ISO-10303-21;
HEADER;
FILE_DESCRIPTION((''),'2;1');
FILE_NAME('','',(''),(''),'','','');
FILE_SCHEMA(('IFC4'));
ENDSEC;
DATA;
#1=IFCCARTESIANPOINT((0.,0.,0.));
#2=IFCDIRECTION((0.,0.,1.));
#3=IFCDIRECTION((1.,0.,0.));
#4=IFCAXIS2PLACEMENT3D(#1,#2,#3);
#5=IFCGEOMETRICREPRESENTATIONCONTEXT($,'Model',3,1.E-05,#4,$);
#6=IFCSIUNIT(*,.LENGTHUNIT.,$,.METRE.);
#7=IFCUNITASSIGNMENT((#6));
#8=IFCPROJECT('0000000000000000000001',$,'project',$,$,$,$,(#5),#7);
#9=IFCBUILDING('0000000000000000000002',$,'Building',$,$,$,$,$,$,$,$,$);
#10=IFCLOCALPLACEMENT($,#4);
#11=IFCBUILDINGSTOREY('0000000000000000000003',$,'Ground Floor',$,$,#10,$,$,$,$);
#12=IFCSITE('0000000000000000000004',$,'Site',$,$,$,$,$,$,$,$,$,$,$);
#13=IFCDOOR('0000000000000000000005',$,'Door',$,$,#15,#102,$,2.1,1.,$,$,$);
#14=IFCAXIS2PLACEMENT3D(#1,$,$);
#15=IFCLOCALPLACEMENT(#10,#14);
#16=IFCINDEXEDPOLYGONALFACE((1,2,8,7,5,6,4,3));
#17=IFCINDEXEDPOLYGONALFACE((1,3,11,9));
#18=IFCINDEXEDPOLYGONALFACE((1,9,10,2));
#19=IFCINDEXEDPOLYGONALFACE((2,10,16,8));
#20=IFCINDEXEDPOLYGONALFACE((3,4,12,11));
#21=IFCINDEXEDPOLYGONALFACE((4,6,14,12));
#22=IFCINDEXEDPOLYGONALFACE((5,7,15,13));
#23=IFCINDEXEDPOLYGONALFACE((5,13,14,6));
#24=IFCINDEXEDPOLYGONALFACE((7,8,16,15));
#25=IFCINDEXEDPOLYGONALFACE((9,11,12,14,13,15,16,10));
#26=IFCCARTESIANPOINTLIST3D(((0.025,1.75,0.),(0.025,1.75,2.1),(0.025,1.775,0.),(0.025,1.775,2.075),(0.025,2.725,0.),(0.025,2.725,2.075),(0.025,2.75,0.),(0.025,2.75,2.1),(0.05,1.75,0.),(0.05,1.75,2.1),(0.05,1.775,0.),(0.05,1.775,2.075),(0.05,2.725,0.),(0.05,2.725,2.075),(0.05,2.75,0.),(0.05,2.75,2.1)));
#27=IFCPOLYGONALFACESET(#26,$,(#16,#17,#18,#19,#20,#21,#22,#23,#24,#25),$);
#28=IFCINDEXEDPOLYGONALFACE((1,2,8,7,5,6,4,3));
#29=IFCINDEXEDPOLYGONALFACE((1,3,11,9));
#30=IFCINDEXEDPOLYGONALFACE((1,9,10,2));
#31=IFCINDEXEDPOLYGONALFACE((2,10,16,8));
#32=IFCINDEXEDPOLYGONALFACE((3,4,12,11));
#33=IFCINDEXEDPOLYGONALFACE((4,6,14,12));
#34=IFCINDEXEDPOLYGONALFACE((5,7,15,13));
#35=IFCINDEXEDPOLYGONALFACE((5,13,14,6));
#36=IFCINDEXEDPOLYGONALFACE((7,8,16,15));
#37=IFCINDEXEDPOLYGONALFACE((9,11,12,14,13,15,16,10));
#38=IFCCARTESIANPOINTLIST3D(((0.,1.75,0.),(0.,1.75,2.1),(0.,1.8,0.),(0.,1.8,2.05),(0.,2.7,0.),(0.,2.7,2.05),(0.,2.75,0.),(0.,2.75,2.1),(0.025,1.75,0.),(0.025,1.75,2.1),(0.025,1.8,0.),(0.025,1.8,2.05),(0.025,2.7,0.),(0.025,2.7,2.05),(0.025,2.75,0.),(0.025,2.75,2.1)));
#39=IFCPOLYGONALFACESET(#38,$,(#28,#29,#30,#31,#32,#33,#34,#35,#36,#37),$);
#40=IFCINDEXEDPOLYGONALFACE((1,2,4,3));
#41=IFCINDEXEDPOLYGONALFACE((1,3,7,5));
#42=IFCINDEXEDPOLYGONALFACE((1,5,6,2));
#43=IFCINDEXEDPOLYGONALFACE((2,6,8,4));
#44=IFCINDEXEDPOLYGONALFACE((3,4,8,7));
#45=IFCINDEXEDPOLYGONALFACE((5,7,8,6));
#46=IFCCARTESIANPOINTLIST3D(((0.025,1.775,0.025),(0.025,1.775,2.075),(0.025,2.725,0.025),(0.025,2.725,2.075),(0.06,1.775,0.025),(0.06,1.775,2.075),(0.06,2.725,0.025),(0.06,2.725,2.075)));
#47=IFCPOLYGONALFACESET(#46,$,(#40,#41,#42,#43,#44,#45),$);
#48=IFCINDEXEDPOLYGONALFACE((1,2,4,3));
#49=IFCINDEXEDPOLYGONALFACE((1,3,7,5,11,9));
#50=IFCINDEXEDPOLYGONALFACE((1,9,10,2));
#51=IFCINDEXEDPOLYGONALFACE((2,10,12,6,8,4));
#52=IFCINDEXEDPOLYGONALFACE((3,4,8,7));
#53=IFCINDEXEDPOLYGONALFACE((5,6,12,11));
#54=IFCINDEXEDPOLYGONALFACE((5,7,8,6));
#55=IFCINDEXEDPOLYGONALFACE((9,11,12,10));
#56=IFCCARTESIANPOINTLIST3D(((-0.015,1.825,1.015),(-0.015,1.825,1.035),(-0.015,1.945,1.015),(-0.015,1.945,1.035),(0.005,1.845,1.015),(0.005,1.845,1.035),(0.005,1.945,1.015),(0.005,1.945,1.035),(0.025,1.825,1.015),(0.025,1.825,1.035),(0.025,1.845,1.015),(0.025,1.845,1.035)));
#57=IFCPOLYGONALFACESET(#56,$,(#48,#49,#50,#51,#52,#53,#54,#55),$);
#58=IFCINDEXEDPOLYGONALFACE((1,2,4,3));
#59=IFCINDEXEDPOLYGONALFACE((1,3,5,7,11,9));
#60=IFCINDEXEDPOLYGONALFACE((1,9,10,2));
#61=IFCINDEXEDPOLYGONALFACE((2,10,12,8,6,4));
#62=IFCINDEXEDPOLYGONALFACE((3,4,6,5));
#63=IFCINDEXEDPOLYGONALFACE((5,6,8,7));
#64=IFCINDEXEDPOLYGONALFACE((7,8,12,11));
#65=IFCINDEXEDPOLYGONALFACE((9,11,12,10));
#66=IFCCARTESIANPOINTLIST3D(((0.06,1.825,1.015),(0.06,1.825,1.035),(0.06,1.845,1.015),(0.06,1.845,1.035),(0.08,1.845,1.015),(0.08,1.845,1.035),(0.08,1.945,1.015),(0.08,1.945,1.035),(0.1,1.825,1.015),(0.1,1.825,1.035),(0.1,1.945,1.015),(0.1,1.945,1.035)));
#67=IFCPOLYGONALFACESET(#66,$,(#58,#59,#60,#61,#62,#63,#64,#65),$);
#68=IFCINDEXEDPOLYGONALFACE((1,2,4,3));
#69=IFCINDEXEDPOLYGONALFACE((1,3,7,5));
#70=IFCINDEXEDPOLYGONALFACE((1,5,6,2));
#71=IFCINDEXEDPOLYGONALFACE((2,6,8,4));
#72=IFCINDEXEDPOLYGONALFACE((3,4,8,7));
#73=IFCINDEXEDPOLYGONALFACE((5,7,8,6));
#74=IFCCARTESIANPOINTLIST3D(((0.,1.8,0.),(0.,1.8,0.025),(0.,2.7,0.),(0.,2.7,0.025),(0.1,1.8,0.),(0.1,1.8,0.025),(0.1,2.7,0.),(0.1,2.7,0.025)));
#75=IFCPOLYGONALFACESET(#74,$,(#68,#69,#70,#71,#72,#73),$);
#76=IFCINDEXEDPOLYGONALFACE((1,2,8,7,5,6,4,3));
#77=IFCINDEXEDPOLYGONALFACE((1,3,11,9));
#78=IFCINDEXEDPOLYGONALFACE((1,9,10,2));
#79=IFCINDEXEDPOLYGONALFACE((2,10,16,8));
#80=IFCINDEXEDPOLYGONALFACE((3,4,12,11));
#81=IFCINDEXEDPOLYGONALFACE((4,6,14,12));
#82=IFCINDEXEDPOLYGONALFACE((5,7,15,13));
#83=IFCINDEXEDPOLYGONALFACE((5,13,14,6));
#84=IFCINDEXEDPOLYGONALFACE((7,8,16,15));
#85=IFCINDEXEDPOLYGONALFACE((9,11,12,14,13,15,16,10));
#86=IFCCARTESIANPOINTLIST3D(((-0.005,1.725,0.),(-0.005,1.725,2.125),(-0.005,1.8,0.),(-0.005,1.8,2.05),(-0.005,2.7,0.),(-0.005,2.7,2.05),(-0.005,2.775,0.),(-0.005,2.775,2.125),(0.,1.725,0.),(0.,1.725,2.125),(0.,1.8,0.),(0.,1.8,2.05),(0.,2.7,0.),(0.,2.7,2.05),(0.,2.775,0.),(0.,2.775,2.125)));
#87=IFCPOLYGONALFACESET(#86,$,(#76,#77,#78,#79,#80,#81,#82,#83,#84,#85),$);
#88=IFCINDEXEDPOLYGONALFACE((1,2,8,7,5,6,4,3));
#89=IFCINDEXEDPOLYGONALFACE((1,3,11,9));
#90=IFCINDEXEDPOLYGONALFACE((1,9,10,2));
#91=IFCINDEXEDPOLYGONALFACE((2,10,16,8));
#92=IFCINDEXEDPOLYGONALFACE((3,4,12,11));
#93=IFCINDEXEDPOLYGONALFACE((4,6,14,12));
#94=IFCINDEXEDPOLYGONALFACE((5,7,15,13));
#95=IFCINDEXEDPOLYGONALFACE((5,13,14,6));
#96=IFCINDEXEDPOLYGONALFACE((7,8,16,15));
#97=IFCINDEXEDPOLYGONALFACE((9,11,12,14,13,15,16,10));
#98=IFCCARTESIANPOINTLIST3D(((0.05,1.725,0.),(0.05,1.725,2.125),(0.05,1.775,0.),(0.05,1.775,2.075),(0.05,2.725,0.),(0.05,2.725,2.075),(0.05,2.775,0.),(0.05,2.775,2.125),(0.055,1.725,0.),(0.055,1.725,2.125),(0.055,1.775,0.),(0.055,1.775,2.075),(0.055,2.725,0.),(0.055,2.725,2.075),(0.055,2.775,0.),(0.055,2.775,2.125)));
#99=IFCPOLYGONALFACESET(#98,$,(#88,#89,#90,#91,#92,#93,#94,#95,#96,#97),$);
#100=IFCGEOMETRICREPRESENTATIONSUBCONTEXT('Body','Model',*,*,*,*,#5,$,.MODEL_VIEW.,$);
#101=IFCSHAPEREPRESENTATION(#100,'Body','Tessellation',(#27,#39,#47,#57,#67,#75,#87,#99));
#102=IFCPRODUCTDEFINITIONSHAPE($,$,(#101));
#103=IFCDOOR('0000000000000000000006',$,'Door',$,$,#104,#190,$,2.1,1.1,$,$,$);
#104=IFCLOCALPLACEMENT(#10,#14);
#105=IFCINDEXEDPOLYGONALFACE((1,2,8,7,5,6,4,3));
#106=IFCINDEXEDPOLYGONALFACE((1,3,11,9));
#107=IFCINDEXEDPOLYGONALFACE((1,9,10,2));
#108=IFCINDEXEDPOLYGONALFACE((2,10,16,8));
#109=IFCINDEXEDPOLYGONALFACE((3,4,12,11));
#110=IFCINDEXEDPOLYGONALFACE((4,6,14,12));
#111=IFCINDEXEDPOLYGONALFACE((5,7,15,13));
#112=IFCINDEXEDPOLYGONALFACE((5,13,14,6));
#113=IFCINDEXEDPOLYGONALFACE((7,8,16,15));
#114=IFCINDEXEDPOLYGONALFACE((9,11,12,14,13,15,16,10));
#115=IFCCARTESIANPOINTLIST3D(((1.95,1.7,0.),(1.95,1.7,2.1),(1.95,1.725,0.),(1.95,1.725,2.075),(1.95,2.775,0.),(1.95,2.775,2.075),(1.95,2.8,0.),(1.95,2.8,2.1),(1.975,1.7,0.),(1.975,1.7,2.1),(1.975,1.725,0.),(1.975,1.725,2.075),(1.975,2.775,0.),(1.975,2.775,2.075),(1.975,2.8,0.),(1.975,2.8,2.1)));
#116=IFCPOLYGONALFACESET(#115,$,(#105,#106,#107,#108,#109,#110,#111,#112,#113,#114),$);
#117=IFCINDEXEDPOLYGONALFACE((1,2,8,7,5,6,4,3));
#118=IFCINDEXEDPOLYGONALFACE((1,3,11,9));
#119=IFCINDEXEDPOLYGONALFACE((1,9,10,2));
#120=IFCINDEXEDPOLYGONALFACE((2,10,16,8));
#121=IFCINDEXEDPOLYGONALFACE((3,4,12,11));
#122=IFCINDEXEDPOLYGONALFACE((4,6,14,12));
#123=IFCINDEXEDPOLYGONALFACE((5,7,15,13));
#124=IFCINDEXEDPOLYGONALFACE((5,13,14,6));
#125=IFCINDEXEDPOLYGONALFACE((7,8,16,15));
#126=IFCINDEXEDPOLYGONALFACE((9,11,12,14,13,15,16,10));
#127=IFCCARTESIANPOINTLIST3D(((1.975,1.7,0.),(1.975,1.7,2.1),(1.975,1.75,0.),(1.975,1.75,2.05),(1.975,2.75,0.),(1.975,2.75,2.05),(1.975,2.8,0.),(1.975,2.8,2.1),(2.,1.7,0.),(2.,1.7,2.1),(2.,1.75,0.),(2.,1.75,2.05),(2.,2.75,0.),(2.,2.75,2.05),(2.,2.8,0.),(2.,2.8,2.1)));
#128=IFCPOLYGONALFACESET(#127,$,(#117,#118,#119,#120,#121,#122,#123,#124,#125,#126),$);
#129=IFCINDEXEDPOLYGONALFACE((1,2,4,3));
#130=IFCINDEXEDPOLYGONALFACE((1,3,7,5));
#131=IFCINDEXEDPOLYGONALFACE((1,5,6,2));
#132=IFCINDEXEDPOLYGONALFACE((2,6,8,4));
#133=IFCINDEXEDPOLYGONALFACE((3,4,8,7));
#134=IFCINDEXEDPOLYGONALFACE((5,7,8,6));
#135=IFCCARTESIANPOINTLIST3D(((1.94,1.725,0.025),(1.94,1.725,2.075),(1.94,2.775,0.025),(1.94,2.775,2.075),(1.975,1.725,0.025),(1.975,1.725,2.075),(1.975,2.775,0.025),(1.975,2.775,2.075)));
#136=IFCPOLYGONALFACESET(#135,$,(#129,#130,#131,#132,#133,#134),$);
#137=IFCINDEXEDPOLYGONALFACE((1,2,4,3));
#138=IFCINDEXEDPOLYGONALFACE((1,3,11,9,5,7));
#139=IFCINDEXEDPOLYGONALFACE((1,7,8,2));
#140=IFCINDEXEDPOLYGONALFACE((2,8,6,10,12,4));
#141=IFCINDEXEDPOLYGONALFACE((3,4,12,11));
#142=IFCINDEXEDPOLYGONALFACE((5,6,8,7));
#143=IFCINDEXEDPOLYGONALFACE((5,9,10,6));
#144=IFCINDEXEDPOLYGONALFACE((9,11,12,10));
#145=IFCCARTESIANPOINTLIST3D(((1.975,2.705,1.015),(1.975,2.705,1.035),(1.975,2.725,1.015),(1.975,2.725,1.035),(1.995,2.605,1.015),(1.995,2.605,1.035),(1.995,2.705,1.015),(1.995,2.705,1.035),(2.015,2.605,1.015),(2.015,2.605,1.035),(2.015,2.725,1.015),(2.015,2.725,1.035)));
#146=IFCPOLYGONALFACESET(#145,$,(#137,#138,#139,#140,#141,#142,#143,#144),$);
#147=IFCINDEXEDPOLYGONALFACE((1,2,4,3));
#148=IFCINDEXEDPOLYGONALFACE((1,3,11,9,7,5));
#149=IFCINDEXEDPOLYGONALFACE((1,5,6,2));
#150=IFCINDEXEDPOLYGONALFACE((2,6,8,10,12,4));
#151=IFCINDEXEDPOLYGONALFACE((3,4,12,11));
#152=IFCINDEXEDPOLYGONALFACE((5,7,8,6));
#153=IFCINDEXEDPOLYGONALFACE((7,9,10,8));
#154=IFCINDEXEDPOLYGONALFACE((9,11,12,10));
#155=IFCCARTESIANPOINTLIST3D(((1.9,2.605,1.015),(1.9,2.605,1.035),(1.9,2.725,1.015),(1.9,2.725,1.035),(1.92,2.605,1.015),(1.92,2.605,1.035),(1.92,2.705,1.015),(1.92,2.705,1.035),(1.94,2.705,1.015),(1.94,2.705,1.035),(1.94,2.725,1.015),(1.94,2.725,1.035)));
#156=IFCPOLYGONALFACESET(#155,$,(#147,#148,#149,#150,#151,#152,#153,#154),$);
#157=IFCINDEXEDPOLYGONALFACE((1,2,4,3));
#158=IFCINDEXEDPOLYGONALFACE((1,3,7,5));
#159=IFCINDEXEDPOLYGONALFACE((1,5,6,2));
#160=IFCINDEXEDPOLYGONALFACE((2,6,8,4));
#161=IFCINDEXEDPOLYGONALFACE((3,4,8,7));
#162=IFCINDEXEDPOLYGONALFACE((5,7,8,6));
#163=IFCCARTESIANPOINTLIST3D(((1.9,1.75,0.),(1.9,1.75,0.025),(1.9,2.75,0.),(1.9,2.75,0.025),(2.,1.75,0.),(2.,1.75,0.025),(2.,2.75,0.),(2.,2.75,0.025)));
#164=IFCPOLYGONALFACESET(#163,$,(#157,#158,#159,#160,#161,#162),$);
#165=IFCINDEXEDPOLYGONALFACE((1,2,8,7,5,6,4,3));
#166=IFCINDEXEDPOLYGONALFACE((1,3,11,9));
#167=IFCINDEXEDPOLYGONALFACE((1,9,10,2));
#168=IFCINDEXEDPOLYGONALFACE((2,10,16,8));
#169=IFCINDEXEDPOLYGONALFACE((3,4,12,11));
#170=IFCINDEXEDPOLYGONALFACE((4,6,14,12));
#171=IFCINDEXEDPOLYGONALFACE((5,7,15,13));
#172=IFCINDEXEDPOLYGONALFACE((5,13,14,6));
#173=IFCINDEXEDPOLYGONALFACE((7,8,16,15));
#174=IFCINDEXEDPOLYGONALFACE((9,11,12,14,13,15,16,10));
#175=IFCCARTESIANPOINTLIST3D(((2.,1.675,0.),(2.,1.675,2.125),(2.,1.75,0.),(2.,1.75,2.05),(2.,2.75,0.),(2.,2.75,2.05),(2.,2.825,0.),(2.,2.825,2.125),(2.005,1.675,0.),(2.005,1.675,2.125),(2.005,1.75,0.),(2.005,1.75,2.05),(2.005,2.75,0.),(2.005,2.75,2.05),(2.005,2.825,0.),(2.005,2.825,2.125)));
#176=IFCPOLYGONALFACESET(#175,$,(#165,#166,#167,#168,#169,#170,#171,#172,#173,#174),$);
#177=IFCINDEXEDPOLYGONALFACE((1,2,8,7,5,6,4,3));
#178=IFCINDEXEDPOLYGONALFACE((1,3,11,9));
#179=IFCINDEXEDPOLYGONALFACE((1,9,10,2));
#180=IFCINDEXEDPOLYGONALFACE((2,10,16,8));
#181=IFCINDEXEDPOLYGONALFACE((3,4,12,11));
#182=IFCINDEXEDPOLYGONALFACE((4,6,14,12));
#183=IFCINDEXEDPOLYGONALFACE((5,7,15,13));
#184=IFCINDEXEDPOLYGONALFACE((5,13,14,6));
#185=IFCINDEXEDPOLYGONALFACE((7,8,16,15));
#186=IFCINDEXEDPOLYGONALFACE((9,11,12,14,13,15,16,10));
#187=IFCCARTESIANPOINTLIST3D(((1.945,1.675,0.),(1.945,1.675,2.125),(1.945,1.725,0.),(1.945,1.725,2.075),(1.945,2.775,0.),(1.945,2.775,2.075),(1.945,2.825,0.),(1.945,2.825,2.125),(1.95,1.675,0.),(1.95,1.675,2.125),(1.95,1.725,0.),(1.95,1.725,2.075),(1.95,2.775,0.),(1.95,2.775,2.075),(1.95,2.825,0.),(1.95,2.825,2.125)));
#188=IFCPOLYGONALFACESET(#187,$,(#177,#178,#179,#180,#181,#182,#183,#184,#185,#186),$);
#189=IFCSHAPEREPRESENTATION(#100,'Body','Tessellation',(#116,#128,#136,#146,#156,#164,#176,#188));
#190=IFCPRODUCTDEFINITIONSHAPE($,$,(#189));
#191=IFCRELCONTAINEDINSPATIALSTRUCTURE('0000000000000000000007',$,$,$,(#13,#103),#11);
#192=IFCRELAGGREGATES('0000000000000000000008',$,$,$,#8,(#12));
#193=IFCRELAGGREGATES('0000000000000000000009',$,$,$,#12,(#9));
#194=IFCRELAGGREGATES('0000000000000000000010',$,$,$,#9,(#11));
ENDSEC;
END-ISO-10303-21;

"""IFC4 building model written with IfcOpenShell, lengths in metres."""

from ifc_helpers import new_model, si_unit, frame, origin_with_axes, place, context, subcontext, project, spatial, line, indexed_curve, outline, extrude, element, save


model = new_model("IFC4")

# Units and contexts
model_context = context("Model", 3, precision=1e-05, world=origin_with_axes())
body_context = subcontext(model_context, "Body", "Model", "MODEL_VIEW")
ifc_project = project(units=[si_unit("LENGTHUNIT", "METRE")], contexts=[model_context])

# Site, building, storey
site = spatial("IfcSite", under=ifc_project, Name="Site")
building = spatial("IfcBuilding", under=site, Name="Building")
storey_placement = place(None, origin_with_axes())
storey = spatial("IfcBuildingStorey", under=building, at=storey_placement, Name="Ground Floor")

# Doors
door_1_placement = place(storey_placement, frame((0.0, 2.75, 0.0), z_axis=(0.0, 0.0, 1.0), x_axis=(0.0, -1.0, 0.0)))
element("IfcDoor", 1, at=door_1_placement, inside=storey, Name="Door", OverallHeight=2.1, OverallWidth=1.0, context=body_context, shape_type="SweptSolid", body=[
    extrude(outline(indexed_curve([(0.0, 0.0), (0.0, 2.1), (1.0, 2.1), (1.0, 0.0), (0.975, 0.0), (0.975, 2.075), (0.025, 2.075), (0.025, 0.0)], segments=[line(1, 2, 3, 4, 5, 6, 7, 8, 1)])), frame((0.0, 0.025, 0.0), z_axis=(0.0, -1.0, 0.0), x_axis=(1.0, 0.0, 0.0)), (0.0, 0.0, -1.0), 0.025),
    extrude(outline(indexed_curve([(0.0, 0.0), (0.0, 2.1), (1.0, 2.1), (1.0, 0.0), (0.95, 0.0), (0.95, 2.05), (0.05, 2.05), (0.05, 0.0)], segments=[line(1, 2, 3, 4, 5, 6, 7, 8, 1)])), frame((0.0, 0.0, 0.0), z_axis=(0.0, -1.0, 0.0), x_axis=(1.0, 0.0, 0.0)), (0.0, 0.0, -1.0), 0.025),
    extrude(outline(indexed_curve([(0.0, 0.0), (0.95, 0.0), (0.95, 0.035), (0.0, 0.035)], segments=[line(1, 2, 3, 4, 1)])), frame((0.025, 0.025, 0.025), z_axis=(0.0, 0.0, 1.0), x_axis=(1.0, 0.0, 0.0)), (0.0, 0.0, 1.0), 2.05),
    extrude(outline(indexed_curve([(0.0, 0.0), (0.0, -0.04), (-0.12, -0.04), (-0.12, -0.02), (-0.02, -0.02), (-0.02, 0.0)], segments=[line(1, 2, 3, 4, 5, 6, 1)])), frame((0.925, 0.025, 1.015), z_axis=(0.0, 0.0, 1.0), x_axis=(1.0, 0.0, 0.0)), (0.0, 0.0, 1.0), 0.02),
    extrude(outline(indexed_curve([(0.0, 0.0), (0.0, 0.04), (-0.12, 0.04), (-0.12, 0.02), (-0.02, 0.02), (-0.02, 0.0)], segments=[line(1, 2, 3, 4, 5, 6, 1)])), frame((0.925, 0.06, 1.015), z_axis=(0.0, 0.0, 1.0), x_axis=(1.0, 0.0, 0.0)), (0.0, 0.0, 1.0), 0.02),
    extrude(outline(indexed_curve([(0.0, 0.0), (0.9, 0.0), (0.9, 0.1), (0.0, 0.1)], segments=[line(1, 2, 3, 4, 1)])), frame((0.05, 0.0, 0.0), z_axis=(0.0, 0.0, 1.0), x_axis=(1.0, 0.0, 0.0)), (0.0, 0.0, 1.0), 0.025),
    extrude(outline(indexed_curve([(0.0, 0.0), (0.0, 2.125), (1.05, 2.125), (1.05, 0.0), (0.975, 0.0), (0.975, 2.05), (0.075, 2.05), (0.075, 0.0)], segments=[line(1, 2, 3, 4, 5, 6, 7, 8, 1)])), frame((-0.025, -0.005, 0.0), z_axis=(0.0, -1.0, 0.0), x_axis=(1.0, 0.0, 0.0)), (0.0, 0.0, -1.0), 0.005),
    extrude(outline(indexed_curve([(0.0, 0.0), (0.0, 2.125), (1.05, 2.125), (1.05, 0.0), (1.0, 0.0), (1.0, 2.075), (0.05, 2.075), (0.05, 0.0)], segments=[line(1, 2, 3, 4, 5, 6, 7, 8, 1)])), frame((-0.025, 0.05, 0.0), z_axis=(0.0, -1.0, 0.0), x_axis=(1.0, 0.0, 0.0)), (0.0, 0.0, -1.0), 0.005),
])
door_2_placement = place(storey_placement, frame((2.0, 1.7, 0.0), z_axis=(0.0, 0.0, 1.0), x_axis=(0.0, 1.0, 0.0)))
element("IfcDoor", 2, at=door_2_placement, inside=storey, Name="Door", OverallHeight=2.1, OverallWidth=1.1, context=body_context, shape_type="SweptSolid", body=[
    extrude(outline(indexed_curve([(0.0, 0.0), (0.0, 2.1), (1.1, 2.1), (1.1, 0.0), (1.075, 0.0), (1.075, 2.075), (0.025, 2.075), (0.025, 0.0)], segments=[line(1, 2, 3, 4, 5, 6, 7, 8, 1)])), frame((0.0, 0.025, 0.0), z_axis=(0.0, -1.0, 0.0), x_axis=(1.0, 0.0, 0.0)), (0.0, 0.0, -1.0), 0.025),
    extrude(outline(indexed_curve([(0.0, 0.0), (0.0, 2.1), (1.1, 2.1), (1.1, 0.0), (1.05, 0.0), (1.05, 2.05), (0.05, 2.05), (0.05, 0.0)], segments=[line(1, 2, 3, 4, 5, 6, 7, 8, 1)])), frame((0.0, 0.0, 0.0), z_axis=(0.0, -1.0, 0.0), x_axis=(1.0, 0.0, 0.0)), (0.0, 0.0, -1.0), 0.025),
    extrude(outline(indexed_curve([(0.0, 0.0), (1.05, 0.0), (1.05, 0.035), (0.0, 0.035)], segments=[line(1, 2, 3, 4, 1)])), frame((0.025, 0.025, 0.025), z_axis=(0.0, 0.0, 1.0), x_axis=(1.0, 0.0, 0.0)), (0.0, 0.0, 1.0), 2.05),
    extrude(outline(indexed_curve([(0.0, 0.0), (0.0, -0.04), (-0.12, -0.04), (-0.12, -0.02), (-0.02, -0.02), (-0.02, 0.0)], segments=[line(1, 2, 3, 4, 5, 6, 1)])), frame((1.025, 0.025, 1.015), z_axis=(0.0, 0.0, 1.0), x_axis=(1.0, 0.0, 0.0)), (0.0, 0.0, 1.0), 0.02),
    extrude(outline(indexed_curve([(0.0, 0.0), (0.0, 0.04), (-0.12, 0.04), (-0.12, 0.02), (-0.02, 0.02), (-0.02, 0.0)], segments=[line(1, 2, 3, 4, 5, 6, 1)])), frame((1.025, 0.06, 1.015), z_axis=(0.0, 0.0, 1.0), x_axis=(1.0, 0.0, 0.0)), (0.0, 0.0, 1.0), 0.02),
    extrude(outline(indexed_curve([(0.0, 0.0), (1.0, 0.0), (1.0, 0.1), (0.0, 0.1)], segments=[line(1, 2, 3, 4, 1)])), frame((0.05, 0.0, 0.0), z_axis=(0.0, 0.0, 1.0), x_axis=(1.0, 0.0, 0.0)), (0.0, 0.0, 1.0), 0.025),
    extrude(outline(indexed_curve([(0.0, 0.0), (0.0, 2.125), (1.15, 2.125), (1.15, 0.0), (1.075, 0.0), (1.075, 2.05), (0.075, 2.05), (0.075, 0.0)], segments=[line(1, 2, 3, 4, 5, 6, 7, 8, 1)])), frame((-0.025, -0.005, 0.0), z_axis=(0.0, -1.0, 0.0), x_axis=(1.0, 0.0, 0.0)), (0.0, 0.0, -1.0), 0.005),
    extrude(outline(indexed_curve([(0.0, 0.0), (0.0, 2.125), (1.15, 2.125), (1.15, 0.0), (1.1, 0.0), (1.1, 2.075), (0.05, 2.075), (0.05, 0.0)], segments=[line(1, 2, 3, 4, 5, 6, 7, 8, 1)])), frame((-0.025, 0.05, 0.0), z_axis=(0.0, -1.0, 0.0), x_axis=(1.0, 0.0, 0.0)), (0.0, 0.0, -1.0), 0.005),
])

save(model, "model.ifc")
